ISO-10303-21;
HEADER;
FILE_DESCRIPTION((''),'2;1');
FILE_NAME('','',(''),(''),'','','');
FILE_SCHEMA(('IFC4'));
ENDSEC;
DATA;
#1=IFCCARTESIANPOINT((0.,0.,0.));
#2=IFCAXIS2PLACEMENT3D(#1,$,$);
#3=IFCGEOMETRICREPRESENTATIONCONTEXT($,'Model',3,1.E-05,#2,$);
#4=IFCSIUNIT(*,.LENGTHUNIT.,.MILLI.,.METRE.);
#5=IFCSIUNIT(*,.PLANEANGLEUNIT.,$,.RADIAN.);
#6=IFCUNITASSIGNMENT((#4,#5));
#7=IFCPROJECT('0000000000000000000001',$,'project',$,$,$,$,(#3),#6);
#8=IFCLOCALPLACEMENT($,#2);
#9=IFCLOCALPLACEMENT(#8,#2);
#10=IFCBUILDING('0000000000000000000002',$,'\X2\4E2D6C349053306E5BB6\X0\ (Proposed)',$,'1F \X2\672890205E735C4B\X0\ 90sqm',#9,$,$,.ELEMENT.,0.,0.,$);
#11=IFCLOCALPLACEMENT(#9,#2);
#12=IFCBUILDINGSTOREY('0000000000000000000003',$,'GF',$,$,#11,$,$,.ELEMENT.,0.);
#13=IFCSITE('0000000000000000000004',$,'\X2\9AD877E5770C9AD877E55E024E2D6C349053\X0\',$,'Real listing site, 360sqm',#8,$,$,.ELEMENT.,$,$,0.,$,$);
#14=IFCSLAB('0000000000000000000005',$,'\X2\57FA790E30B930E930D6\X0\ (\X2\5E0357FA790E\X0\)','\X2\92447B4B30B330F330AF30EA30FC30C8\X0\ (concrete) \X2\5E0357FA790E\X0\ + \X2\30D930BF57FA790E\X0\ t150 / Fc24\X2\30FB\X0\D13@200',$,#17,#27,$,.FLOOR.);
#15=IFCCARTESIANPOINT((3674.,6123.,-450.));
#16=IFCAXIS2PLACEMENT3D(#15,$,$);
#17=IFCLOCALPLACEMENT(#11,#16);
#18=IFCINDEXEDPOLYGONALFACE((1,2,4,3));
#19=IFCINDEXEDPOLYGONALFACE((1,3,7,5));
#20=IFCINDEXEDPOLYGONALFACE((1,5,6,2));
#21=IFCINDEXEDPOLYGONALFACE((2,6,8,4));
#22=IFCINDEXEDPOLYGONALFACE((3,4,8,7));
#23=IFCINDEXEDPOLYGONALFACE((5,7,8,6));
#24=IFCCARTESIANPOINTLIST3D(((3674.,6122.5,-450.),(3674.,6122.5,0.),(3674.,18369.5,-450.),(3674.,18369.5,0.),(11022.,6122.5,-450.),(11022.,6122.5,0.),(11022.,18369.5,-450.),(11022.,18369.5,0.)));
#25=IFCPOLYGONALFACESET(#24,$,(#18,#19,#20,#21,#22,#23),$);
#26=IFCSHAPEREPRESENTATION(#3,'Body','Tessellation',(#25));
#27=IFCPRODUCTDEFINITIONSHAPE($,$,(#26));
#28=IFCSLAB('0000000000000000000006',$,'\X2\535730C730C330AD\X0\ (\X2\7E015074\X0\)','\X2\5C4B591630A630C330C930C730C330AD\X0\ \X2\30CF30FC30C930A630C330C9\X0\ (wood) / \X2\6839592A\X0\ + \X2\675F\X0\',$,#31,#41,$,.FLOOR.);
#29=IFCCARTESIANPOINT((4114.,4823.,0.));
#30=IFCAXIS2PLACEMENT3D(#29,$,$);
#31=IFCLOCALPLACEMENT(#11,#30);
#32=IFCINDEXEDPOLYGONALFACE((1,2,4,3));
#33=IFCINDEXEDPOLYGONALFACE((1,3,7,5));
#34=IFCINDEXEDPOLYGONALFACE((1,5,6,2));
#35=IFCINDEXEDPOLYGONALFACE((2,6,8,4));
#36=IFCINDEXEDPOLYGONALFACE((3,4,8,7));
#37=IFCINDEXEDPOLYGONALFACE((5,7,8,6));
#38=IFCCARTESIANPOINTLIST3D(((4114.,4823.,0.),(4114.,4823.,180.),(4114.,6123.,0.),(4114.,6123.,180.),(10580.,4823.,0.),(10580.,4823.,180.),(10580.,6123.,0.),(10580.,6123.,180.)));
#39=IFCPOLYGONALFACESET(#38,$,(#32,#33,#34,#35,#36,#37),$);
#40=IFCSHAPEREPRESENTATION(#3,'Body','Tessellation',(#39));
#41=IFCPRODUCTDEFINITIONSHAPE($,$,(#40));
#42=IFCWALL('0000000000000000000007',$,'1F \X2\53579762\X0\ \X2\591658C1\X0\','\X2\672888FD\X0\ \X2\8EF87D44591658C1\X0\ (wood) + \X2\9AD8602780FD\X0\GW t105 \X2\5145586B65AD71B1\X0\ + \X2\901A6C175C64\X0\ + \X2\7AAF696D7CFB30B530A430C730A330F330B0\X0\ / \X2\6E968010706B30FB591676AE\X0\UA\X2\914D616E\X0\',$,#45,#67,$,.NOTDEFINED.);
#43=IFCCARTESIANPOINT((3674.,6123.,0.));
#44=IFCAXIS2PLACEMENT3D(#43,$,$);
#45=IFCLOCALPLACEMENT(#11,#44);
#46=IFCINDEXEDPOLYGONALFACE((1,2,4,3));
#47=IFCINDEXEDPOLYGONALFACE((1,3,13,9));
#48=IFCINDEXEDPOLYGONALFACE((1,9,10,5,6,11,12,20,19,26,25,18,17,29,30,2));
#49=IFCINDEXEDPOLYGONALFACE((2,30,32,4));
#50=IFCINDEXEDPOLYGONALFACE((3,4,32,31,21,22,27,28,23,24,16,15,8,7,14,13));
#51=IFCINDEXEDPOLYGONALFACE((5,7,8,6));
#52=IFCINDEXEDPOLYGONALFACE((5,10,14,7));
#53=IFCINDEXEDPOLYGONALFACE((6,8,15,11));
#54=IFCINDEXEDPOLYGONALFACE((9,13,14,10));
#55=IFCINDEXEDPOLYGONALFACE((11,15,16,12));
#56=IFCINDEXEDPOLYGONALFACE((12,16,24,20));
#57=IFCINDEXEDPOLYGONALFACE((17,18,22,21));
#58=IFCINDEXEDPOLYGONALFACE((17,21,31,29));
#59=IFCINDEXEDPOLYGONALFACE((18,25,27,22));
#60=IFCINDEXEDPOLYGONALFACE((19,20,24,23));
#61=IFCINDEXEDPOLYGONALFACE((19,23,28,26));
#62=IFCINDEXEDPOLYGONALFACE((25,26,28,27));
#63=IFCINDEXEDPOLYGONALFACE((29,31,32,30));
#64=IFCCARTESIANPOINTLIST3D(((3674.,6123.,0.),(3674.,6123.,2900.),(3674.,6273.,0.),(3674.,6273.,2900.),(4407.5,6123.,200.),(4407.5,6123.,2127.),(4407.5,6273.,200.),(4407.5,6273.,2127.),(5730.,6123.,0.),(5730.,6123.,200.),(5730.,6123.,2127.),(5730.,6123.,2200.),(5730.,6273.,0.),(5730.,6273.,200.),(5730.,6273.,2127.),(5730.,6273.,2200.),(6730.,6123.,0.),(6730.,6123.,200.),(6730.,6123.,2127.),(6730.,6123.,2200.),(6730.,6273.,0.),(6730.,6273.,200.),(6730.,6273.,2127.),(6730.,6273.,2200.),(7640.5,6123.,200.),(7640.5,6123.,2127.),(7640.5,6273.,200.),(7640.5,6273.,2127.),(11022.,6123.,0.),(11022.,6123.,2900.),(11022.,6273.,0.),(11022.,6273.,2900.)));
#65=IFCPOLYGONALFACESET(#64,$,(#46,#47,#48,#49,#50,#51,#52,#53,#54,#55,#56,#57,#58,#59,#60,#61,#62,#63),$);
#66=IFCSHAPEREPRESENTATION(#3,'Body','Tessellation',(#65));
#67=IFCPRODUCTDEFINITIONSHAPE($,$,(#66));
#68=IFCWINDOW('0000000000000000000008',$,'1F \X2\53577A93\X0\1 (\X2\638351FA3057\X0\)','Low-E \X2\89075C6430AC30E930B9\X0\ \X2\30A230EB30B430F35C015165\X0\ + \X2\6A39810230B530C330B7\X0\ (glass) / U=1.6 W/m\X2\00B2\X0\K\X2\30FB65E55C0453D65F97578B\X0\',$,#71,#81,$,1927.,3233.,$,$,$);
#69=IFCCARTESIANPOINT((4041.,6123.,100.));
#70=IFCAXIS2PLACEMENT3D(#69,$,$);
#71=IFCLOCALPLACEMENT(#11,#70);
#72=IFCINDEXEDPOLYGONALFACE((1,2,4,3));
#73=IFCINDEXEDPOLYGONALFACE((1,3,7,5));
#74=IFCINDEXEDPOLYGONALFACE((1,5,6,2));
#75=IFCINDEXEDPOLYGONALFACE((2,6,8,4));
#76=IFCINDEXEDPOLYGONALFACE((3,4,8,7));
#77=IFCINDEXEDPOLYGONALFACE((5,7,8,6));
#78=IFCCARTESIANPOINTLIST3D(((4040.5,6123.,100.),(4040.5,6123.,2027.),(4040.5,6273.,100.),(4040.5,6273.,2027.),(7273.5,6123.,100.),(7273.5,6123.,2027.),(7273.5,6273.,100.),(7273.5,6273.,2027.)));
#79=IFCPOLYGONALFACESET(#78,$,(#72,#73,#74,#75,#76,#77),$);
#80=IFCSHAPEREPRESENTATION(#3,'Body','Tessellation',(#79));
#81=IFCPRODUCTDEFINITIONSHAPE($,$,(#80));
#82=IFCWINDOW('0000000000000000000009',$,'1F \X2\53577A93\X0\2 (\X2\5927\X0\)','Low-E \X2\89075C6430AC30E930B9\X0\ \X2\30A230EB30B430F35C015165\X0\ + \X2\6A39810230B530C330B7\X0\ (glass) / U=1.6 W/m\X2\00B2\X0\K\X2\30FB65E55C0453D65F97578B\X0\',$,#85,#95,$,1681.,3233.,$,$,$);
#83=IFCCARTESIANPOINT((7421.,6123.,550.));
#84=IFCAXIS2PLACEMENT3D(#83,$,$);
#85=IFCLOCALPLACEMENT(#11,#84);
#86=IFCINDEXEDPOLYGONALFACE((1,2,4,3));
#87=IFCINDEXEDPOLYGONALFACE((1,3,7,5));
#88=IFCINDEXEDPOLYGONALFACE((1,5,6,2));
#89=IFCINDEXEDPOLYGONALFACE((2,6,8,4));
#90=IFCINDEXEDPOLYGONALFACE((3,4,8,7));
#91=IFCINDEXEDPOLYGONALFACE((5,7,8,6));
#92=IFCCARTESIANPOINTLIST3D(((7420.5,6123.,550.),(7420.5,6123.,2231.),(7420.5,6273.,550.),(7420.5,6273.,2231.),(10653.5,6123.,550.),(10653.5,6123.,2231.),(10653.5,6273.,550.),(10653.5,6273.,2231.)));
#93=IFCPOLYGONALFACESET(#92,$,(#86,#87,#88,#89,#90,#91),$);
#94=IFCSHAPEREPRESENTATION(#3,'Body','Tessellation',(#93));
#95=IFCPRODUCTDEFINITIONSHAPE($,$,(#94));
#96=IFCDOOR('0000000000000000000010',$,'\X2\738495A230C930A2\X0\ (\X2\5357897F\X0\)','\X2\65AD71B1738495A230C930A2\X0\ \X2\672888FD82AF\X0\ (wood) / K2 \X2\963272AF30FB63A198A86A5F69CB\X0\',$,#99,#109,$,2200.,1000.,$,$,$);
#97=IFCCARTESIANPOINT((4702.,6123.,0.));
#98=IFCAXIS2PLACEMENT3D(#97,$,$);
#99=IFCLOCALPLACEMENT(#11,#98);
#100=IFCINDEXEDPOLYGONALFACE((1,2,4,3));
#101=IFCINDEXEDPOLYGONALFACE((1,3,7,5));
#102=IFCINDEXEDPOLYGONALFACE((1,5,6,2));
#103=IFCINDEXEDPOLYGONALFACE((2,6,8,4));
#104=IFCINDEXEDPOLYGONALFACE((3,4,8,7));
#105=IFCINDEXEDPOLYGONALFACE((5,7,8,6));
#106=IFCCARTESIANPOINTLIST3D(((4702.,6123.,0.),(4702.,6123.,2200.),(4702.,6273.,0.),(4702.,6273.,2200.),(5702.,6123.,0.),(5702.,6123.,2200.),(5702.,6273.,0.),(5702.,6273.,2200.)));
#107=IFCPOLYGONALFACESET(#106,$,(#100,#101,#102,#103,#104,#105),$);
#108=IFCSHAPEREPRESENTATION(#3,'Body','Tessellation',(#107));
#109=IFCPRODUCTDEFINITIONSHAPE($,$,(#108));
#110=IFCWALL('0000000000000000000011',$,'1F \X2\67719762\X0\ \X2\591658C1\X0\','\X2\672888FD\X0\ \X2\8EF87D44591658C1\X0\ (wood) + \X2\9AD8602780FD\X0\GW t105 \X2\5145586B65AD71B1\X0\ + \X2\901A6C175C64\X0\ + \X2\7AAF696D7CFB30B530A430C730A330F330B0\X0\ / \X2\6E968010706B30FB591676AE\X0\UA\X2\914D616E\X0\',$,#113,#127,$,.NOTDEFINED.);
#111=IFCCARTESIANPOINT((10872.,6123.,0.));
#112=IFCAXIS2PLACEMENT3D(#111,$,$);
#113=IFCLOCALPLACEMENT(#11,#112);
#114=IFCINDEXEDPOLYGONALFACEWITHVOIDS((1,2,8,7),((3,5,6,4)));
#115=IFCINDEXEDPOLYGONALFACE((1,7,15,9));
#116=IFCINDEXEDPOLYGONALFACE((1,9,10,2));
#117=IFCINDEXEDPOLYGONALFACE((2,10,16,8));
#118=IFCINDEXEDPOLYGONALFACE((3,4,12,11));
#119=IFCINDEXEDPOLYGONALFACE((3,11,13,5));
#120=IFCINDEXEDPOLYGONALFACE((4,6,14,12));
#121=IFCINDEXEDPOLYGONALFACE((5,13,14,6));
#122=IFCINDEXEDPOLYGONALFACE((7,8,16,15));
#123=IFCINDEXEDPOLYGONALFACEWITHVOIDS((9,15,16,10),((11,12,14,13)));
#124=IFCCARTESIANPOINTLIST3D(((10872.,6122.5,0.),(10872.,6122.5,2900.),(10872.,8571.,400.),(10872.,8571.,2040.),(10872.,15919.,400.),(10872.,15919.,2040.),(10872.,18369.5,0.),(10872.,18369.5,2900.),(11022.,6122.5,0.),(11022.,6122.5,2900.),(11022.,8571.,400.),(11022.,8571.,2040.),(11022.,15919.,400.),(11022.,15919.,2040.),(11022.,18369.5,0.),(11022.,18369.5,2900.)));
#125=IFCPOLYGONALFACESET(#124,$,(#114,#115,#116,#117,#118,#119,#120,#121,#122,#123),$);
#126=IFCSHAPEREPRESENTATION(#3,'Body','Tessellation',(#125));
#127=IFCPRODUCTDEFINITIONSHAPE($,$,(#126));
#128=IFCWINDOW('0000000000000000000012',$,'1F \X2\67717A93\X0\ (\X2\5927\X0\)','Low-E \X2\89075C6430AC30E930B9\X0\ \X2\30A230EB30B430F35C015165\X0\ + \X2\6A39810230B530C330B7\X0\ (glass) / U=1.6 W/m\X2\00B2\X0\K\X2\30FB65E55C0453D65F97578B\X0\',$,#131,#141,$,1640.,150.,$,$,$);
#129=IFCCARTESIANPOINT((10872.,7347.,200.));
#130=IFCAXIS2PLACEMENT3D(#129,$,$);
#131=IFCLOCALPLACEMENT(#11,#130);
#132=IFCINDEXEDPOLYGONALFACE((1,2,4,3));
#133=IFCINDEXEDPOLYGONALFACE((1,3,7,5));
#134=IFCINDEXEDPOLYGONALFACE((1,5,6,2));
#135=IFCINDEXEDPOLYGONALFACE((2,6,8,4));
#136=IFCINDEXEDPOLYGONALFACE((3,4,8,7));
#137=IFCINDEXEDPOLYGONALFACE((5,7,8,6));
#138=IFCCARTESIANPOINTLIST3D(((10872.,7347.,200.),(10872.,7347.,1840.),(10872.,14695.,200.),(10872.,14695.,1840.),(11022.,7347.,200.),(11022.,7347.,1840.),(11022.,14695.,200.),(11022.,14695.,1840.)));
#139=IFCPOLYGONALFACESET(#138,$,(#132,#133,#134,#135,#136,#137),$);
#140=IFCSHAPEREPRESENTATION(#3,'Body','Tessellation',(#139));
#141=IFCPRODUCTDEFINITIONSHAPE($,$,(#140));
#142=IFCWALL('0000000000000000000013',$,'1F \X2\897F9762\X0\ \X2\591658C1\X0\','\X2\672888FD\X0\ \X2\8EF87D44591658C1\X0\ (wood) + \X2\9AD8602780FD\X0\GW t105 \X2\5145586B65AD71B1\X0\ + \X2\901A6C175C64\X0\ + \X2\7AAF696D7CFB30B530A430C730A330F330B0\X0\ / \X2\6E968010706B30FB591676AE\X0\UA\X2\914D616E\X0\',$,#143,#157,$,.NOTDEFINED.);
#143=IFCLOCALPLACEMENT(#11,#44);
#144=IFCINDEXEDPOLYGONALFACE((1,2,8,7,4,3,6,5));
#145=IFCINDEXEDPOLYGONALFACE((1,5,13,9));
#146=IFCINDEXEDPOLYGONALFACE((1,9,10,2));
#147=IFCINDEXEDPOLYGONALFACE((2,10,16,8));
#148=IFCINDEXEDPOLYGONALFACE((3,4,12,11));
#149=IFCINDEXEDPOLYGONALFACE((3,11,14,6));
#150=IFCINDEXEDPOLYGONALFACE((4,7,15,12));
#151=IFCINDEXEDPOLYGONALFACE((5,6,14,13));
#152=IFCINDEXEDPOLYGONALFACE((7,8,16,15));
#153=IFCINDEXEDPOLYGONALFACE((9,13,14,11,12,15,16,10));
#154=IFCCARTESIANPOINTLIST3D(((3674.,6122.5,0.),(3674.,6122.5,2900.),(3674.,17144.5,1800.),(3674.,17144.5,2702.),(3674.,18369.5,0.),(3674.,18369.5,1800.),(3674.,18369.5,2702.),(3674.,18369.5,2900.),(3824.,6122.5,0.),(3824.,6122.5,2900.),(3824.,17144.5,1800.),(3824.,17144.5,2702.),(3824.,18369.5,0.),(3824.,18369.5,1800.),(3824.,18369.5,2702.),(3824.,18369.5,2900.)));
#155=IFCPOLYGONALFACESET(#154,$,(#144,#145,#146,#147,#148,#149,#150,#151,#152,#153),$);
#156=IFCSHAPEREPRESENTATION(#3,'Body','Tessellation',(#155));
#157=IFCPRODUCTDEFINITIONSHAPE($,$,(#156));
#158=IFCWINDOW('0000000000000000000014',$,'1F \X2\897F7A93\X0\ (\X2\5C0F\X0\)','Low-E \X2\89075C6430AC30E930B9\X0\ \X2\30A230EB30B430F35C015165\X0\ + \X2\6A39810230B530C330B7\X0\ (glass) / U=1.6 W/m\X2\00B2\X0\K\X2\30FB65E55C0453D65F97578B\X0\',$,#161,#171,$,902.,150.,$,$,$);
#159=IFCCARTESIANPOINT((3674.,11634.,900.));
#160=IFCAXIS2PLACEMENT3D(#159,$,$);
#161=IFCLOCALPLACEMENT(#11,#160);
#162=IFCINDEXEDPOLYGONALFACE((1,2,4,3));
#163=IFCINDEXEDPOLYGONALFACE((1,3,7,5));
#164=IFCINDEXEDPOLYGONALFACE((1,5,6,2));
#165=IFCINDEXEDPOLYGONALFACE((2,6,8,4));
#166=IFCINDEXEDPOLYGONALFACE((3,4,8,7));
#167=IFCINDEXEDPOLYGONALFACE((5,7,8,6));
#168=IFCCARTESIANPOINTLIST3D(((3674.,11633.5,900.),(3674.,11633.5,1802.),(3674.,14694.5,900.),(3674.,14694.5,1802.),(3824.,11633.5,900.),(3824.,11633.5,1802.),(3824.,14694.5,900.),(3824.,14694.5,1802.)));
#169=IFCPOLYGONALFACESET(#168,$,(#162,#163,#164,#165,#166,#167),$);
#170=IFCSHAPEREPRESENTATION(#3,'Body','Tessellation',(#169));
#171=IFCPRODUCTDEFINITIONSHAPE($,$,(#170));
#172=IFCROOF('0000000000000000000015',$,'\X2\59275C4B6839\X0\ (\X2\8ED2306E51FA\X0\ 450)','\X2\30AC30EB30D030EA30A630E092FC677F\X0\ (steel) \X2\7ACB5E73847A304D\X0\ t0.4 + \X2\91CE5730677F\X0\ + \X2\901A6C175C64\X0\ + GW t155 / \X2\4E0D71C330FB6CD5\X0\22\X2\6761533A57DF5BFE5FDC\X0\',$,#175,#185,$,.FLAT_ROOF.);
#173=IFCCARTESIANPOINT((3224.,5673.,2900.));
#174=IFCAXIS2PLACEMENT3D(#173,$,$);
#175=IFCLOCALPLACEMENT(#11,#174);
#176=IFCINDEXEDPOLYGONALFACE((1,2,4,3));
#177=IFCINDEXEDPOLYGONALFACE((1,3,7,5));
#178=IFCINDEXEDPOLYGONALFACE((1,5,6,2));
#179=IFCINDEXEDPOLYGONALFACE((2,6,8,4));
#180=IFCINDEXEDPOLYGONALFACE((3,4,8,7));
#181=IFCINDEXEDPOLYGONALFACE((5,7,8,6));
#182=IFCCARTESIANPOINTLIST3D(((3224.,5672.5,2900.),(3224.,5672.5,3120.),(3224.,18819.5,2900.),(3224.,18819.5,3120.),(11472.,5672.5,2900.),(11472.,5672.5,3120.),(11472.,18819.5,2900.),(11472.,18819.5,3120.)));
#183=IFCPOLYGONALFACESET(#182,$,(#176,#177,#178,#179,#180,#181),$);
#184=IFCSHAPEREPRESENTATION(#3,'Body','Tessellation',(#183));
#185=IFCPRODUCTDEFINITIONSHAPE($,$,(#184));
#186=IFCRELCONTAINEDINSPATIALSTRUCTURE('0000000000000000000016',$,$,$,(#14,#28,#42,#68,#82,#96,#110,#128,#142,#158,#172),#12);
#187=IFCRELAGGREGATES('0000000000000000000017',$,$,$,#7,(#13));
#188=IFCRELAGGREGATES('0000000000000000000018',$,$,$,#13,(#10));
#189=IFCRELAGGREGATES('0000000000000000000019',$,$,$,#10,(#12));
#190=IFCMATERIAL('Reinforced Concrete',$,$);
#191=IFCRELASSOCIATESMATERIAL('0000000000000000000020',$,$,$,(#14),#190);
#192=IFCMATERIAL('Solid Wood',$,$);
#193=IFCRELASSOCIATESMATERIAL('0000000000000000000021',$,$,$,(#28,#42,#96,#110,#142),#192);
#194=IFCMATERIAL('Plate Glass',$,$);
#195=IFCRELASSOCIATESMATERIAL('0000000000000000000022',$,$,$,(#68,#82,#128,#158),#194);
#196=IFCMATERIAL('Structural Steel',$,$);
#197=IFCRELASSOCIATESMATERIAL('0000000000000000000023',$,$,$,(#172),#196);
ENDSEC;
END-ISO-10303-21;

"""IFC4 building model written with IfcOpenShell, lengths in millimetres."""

from ifc_helpers import new_model, si_unit, frame, frame_2d, origin, place, context, project, spatial, rectangle, extrude, material, element, fill, save


model = new_model("IFC4")

# Units and contexts
model_context = context("Model", 3, precision=1e-05, world=origin())
ifc_project = project(units=[si_unit("LENGTHUNIT", "METRE", prefix="MILLI"), si_unit("PLANEANGLEUNIT", "RADIAN")], contexts=[model_context])

# Site, building, storey
site_placement = place(None, origin())
site = spatial("IfcSite", under=ifc_project, at=site_placement, Name="高知県高知市中水道", ObjectType="Real listing site, 360sqm", CompositionType="ELEMENT", RefElevation=0.0)
building_placement = place(site_placement, origin())
building = spatial("IfcBuilding", under=site, at=building_placement, Name="中水道の家 (Proposed)", ObjectType="1F 木造平屋 90sqm", CompositionType="ELEMENT", ElevationOfRefHeight=0.0, ElevationOfTerrain=0.0)
storey_placement = place(building_placement, origin())
storey = spatial("IfcBuildingStorey", under=building, at=storey_placement, Name="GF", CompositionType="ELEMENT", Elevation=0.0)

# Slabs
ifc_material_1 = material(Name="Reinforced Concrete")
slab_1_placement = place(storey_placement, frame((3674.0, 6123.0, -450.0)))
element("IfcSlab", 1, at=slab_1_placement, inside=storey, material=ifc_material_1, Name="基礎スラブ (布基礎)", Description="鉄筋コンクリート (concrete) 布基礎 + ベタ基礎 t150 / Fc24・D13@200", PredefinedType="FLOOR", context=model_context, shape_type="SweptSolid", body=[
    extrude(rectangle(XDim=7348.0, YDim=12247.0, at=frame_2d((3674.0, 6123.0))), frame((3674.0, 6123.0, -450.0)), (0.0, 0.0, 1.0), 450.0),
])
ifc_material_2 = material(Name="Solid Wood")
slab_2_placement = place(storey_placement, frame((4114.0, 4823.0, 0.0)))
element("IfcSlab", 2, at=slab_2_placement, inside=storey, material=ifc_material_2, Name="南デッキ (縁側)", Description="屋外ウッドデッキ ハードウッド (wood) / 根太 + 束", PredefinedType="FLOOR", context=model_context, shape_type="SweptSolid", body=[
    extrude(rectangle(XDim=6466.0, YDim=1300.0, at=frame_2d((3233.0, 650.0))), frame((4114.0, 4823.0, 0.0)), (0.0, 0.0, 1.0), 180.0),
])

# Wall, openings, windows, door
wall_1_placement = place(storey_placement, frame((3674.0, 6123.0, 0.0)))
wall_1 = element("IfcWall", 3, at=wall_1_placement, inside=storey, material=ifc_material_2, Name="1F 南面 外壁", Description="木製 軸組外壁 (wood) + 高性能GW t105 充填断熱 + 通気層 + 窯業系サイディング / 準耐火・外皮UA配慮", PredefinedType="NOTDEFINED", context=model_context, shape_type="SweptSolid", body=[
    extrude(rectangle(XDim=7348.0, YDim=150.0, at=frame_2d((3674.0, 75.0))), frame((3674.0, 6123.0, 0.0)), (0.0, 0.0, 1.0), 2900.0),
])
opening_1_placement = place(storey_placement, frame((4041.0, 6123.0, 100.0)))
opening_1 = element("IfcOpeningElement", 4, at=opening_1_placement, cuts=wall_1, PredefinedType="NOTDEFINED", context=model_context, shape_type="SweptSolid", body=[
    extrude(rectangle(XDim=3233.0, YDim=150.0, at=frame_2d((1616.0, 75.0))), frame((4041.0, 6123.0, 100.0)), (0.0, 0.0, 1.0), 1927.0),
])
opening_2_placement = place(storey_placement, frame((7421.0, 6123.0, 550.0)))
opening_2 = element("IfcOpeningElement", 5, at=opening_2_placement, cuts=wall_1, PredefinedType="NOTDEFINED", context=model_context, shape_type="SweptSolid", body=[
    extrude(rectangle(XDim=3233.0, YDim=150.0, at=frame_2d((1616.0, 75.0))), frame((7421.0, 6123.0, 550.0)), (0.0, 0.0, 1.0), 1681.0),
])
opening_3_placement = place(storey_placement, frame((4702.0, 6123.0, 0.0)))
opening_3 = element("IfcOpeningElement", 6, at=opening_3_placement, cuts=wall_1, PredefinedType="NOTDEFINED", context=model_context, shape_type="SweptSolid", body=[
    extrude(rectangle(XDim=1000.0, YDim=150.0, at=frame_2d((500.0, 75.0))), frame((4702.0, 6123.0, 0.0)), (0.0, 0.0, 1.0), 2200.0),
])
ifc_material_3 = material(Name="Plate Glass")
window_1_placement = place(storey_placement, frame((4041.0, 6123.0, 100.0)))
window_1 = element("IfcWindow", 7, at=window_1_placement, inside=storey, material=ifc_material_3, Name="1F 南窓1 (掃出し)", Description="Low-E 複層ガラス アルゴン封入 + 樹脂サッシ (glass) / U=1.6 W/m²K・日射取得型", OverallHeight=1927.0, OverallWidth=3233.0, context=model_context, shape_type="SweptSolid", body=[
    extrude(rectangle(XDim=3233.0, YDim=150.0, at=frame_2d((1616.0, 75.0))), frame((4041.0, 6123.0, 100.0)), (0.0, 0.0, 1.0), 1927.0),
])
fill(opening_1, window_1)
window_2_placement = place(storey_placement, frame((7421.0, 6123.0, 550.0)))
window_2 = element("IfcWindow", 8, at=window_2_placement, inside=storey, material=ifc_material_3, Name="1F 南窓2 (大)", Description="Low-E 複層ガラス アルゴン封入 + 樹脂サッシ (glass) / U=1.6 W/m²K・日射取得型", OverallHeight=1681.0, OverallWidth=3233.0, context=model_context, shape_type="SweptSolid", body=[
    extrude(rectangle(XDim=3233.0, YDim=150.0, at=frame_2d((1616.0, 75.0))), frame((7421.0, 6123.0, 550.0)), (0.0, 0.0, 1.0), 1681.0),
])
fill(opening_2, window_2)
door_placement = place(storey_placement, frame((4702.0, 6123.0, 0.0)))
door = element("IfcDoor", 9, at=door_placement, inside=storey, material=ifc_material_2, Name="玄関ドア (南西)", Description="断熱玄関ドア 木製芯 (wood) / K2 防犯・採風機構", OverallHeight=2200.0, OverallWidth=1000.0, context=model_context, shape_type="SweptSolid", body=[
    extrude(rectangle(XDim=1000.0, YDim=150.0, at=frame_2d((500.0, 75.0))), frame((4702.0, 6123.0, 0.0)), (0.0, 0.0, 1.0), 2200.0),
])
fill(opening_3, door)

# Walls, openings, windows
wall_2_placement = place(storey_placement, frame((10872.0, 6123.0, 0.0)))
wall_2 = element("IfcWall", 10, at=wall_2_placement, inside=storey, material=ifc_material_2, Name="1F 東面 外壁", Description="木製 軸組外壁 (wood) + 高性能GW t105 充填断熱 + 通気層 + 窯業系サイディング / 準耐火・外皮UA配慮", PredefinedType="NOTDEFINED", context=model_context, shape_type="SweptSolid", body=[
    extrude(rectangle(XDim=150.0, YDim=12247.0, at=frame_2d((75.0, 6123.0))), frame((10872.0, 6123.0, 0.0)), (0.0, 0.0, 1.0), 2900.0),
])
opening_4_placement = place(storey_placement, frame((10872.0, 7347.0, 200.0)))
opening_4 = element("IfcOpeningElement", 11, at=opening_4_placement, cuts=wall_2, PredefinedType="NOTDEFINED", context=model_context, shape_type="SweptSolid", body=[
    extrude(rectangle(XDim=150.0, YDim=7348.0, at=frame_2d((75.0, 3674.0))), frame((10872.0, 7347.0, 200.0)), (0.0, 0.0, 1.0), 1640.0),
])
window_3_placement = place(storey_placement, frame((10872.0, 7347.0, 200.0)))
window_3 = element("IfcWindow", 12, at=window_3_placement, inside=storey, material=ifc_material_3, Name="1F 東窓 (大)", Description="Low-E 複層ガラス アルゴン封入 + 樹脂サッシ (glass) / U=1.6 W/m²K・日射取得型", OverallHeight=1640.0, OverallWidth=150.0, context=model_context, shape_type="SweptSolid", body=[
    extrude(rectangle(XDim=150.0, YDim=7348.0, at=frame_2d((75.0, 3674.0))), frame((10872.0, 7347.0, 200.0)), (0.0, 0.0, 1.0), 1640.0),
])
fill(opening_4, window_3)
wall_3_placement = place(storey_placement, frame((3674.0, 6123.0, 0.0)))
wall_3 = element("IfcWall", 13, at=wall_3_placement, inside=storey, material=ifc_material_2, Name="1F 西面 外壁", Description="木製 軸組外壁 (wood) + 高性能GW t105 充填断熱 + 通気層 + 窯業系サイディング / 準耐火・外皮UA配慮", PredefinedType="NOTDEFINED", context=model_context, shape_type="SweptSolid", body=[
    extrude(rectangle(XDim=150.0, YDim=12247.0, at=frame_2d((75.0, 6123.0))), frame((3674.0, 6123.0, 0.0)), (0.0, 0.0, 1.0), 2900.0),
])
opening_5_placement = place(storey_placement, frame((3674.0, 11634.0, 900.0)))
opening_5 = element("IfcOpeningElement", 14, at=opening_5_placement, cuts=wall_3, PredefinedType="NOTDEFINED", context=model_context, shape_type="SweptSolid", body=[
    extrude(rectangle(XDim=150.0, YDim=3061.0, at=frame_2d((75.0, 1530.0))), frame((3674.0, 11634.0, 900.0)), (0.0, 0.0, 1.0), 902.0),
])
window_4_placement = place(storey_placement, frame((3674.0, 11634.0, 900.0)))
window_4 = element("IfcWindow", 15, at=window_4_placement, inside=storey, material=ifc_material_3, Name="1F 西窓 (小)", Description="Low-E 複層ガラス アルゴン封入 + 樹脂サッシ (glass) / U=1.6 W/m²K・日射取得型", OverallHeight=902.0, OverallWidth=150.0, context=model_context, shape_type="SweptSolid", body=[
    extrude(rectangle(XDim=150.0, YDim=3061.0, at=frame_2d((75.0, 1530.0))), frame((3674.0, 11634.0, 900.0)), (0.0, 0.0, 1.0), 902.0),
])
fill(opening_5, window_4)

# Roof
ifc_material_4 = material(Name="Structural Steel")
roof_placement = place(storey_placement, frame((3224.0, 5673.0, 2900.0)))
element("IfcRoof", 16, at=roof_placement, inside=storey, material=ifc_material_4, Name="大屋根 (軒の出 450)", Description="ガルバリウム鋼板 (steel) 立平葺き t0.4 + 野地板 + 通気層 + GW t155 / 不燃・法22条区域対応", PredefinedType="FLAT_ROOF", context=model_context, shape_type="SweptSolid", body=[
    extrude(rectangle(XDim=8248.0, YDim=13147.0, at=frame_2d((4124.0, 6573.0))), frame((3224.0, 5673.0, 2900.0)), (0.0, 0.0, 1.0), 220.0),
])

save(model, "model.ifc")
